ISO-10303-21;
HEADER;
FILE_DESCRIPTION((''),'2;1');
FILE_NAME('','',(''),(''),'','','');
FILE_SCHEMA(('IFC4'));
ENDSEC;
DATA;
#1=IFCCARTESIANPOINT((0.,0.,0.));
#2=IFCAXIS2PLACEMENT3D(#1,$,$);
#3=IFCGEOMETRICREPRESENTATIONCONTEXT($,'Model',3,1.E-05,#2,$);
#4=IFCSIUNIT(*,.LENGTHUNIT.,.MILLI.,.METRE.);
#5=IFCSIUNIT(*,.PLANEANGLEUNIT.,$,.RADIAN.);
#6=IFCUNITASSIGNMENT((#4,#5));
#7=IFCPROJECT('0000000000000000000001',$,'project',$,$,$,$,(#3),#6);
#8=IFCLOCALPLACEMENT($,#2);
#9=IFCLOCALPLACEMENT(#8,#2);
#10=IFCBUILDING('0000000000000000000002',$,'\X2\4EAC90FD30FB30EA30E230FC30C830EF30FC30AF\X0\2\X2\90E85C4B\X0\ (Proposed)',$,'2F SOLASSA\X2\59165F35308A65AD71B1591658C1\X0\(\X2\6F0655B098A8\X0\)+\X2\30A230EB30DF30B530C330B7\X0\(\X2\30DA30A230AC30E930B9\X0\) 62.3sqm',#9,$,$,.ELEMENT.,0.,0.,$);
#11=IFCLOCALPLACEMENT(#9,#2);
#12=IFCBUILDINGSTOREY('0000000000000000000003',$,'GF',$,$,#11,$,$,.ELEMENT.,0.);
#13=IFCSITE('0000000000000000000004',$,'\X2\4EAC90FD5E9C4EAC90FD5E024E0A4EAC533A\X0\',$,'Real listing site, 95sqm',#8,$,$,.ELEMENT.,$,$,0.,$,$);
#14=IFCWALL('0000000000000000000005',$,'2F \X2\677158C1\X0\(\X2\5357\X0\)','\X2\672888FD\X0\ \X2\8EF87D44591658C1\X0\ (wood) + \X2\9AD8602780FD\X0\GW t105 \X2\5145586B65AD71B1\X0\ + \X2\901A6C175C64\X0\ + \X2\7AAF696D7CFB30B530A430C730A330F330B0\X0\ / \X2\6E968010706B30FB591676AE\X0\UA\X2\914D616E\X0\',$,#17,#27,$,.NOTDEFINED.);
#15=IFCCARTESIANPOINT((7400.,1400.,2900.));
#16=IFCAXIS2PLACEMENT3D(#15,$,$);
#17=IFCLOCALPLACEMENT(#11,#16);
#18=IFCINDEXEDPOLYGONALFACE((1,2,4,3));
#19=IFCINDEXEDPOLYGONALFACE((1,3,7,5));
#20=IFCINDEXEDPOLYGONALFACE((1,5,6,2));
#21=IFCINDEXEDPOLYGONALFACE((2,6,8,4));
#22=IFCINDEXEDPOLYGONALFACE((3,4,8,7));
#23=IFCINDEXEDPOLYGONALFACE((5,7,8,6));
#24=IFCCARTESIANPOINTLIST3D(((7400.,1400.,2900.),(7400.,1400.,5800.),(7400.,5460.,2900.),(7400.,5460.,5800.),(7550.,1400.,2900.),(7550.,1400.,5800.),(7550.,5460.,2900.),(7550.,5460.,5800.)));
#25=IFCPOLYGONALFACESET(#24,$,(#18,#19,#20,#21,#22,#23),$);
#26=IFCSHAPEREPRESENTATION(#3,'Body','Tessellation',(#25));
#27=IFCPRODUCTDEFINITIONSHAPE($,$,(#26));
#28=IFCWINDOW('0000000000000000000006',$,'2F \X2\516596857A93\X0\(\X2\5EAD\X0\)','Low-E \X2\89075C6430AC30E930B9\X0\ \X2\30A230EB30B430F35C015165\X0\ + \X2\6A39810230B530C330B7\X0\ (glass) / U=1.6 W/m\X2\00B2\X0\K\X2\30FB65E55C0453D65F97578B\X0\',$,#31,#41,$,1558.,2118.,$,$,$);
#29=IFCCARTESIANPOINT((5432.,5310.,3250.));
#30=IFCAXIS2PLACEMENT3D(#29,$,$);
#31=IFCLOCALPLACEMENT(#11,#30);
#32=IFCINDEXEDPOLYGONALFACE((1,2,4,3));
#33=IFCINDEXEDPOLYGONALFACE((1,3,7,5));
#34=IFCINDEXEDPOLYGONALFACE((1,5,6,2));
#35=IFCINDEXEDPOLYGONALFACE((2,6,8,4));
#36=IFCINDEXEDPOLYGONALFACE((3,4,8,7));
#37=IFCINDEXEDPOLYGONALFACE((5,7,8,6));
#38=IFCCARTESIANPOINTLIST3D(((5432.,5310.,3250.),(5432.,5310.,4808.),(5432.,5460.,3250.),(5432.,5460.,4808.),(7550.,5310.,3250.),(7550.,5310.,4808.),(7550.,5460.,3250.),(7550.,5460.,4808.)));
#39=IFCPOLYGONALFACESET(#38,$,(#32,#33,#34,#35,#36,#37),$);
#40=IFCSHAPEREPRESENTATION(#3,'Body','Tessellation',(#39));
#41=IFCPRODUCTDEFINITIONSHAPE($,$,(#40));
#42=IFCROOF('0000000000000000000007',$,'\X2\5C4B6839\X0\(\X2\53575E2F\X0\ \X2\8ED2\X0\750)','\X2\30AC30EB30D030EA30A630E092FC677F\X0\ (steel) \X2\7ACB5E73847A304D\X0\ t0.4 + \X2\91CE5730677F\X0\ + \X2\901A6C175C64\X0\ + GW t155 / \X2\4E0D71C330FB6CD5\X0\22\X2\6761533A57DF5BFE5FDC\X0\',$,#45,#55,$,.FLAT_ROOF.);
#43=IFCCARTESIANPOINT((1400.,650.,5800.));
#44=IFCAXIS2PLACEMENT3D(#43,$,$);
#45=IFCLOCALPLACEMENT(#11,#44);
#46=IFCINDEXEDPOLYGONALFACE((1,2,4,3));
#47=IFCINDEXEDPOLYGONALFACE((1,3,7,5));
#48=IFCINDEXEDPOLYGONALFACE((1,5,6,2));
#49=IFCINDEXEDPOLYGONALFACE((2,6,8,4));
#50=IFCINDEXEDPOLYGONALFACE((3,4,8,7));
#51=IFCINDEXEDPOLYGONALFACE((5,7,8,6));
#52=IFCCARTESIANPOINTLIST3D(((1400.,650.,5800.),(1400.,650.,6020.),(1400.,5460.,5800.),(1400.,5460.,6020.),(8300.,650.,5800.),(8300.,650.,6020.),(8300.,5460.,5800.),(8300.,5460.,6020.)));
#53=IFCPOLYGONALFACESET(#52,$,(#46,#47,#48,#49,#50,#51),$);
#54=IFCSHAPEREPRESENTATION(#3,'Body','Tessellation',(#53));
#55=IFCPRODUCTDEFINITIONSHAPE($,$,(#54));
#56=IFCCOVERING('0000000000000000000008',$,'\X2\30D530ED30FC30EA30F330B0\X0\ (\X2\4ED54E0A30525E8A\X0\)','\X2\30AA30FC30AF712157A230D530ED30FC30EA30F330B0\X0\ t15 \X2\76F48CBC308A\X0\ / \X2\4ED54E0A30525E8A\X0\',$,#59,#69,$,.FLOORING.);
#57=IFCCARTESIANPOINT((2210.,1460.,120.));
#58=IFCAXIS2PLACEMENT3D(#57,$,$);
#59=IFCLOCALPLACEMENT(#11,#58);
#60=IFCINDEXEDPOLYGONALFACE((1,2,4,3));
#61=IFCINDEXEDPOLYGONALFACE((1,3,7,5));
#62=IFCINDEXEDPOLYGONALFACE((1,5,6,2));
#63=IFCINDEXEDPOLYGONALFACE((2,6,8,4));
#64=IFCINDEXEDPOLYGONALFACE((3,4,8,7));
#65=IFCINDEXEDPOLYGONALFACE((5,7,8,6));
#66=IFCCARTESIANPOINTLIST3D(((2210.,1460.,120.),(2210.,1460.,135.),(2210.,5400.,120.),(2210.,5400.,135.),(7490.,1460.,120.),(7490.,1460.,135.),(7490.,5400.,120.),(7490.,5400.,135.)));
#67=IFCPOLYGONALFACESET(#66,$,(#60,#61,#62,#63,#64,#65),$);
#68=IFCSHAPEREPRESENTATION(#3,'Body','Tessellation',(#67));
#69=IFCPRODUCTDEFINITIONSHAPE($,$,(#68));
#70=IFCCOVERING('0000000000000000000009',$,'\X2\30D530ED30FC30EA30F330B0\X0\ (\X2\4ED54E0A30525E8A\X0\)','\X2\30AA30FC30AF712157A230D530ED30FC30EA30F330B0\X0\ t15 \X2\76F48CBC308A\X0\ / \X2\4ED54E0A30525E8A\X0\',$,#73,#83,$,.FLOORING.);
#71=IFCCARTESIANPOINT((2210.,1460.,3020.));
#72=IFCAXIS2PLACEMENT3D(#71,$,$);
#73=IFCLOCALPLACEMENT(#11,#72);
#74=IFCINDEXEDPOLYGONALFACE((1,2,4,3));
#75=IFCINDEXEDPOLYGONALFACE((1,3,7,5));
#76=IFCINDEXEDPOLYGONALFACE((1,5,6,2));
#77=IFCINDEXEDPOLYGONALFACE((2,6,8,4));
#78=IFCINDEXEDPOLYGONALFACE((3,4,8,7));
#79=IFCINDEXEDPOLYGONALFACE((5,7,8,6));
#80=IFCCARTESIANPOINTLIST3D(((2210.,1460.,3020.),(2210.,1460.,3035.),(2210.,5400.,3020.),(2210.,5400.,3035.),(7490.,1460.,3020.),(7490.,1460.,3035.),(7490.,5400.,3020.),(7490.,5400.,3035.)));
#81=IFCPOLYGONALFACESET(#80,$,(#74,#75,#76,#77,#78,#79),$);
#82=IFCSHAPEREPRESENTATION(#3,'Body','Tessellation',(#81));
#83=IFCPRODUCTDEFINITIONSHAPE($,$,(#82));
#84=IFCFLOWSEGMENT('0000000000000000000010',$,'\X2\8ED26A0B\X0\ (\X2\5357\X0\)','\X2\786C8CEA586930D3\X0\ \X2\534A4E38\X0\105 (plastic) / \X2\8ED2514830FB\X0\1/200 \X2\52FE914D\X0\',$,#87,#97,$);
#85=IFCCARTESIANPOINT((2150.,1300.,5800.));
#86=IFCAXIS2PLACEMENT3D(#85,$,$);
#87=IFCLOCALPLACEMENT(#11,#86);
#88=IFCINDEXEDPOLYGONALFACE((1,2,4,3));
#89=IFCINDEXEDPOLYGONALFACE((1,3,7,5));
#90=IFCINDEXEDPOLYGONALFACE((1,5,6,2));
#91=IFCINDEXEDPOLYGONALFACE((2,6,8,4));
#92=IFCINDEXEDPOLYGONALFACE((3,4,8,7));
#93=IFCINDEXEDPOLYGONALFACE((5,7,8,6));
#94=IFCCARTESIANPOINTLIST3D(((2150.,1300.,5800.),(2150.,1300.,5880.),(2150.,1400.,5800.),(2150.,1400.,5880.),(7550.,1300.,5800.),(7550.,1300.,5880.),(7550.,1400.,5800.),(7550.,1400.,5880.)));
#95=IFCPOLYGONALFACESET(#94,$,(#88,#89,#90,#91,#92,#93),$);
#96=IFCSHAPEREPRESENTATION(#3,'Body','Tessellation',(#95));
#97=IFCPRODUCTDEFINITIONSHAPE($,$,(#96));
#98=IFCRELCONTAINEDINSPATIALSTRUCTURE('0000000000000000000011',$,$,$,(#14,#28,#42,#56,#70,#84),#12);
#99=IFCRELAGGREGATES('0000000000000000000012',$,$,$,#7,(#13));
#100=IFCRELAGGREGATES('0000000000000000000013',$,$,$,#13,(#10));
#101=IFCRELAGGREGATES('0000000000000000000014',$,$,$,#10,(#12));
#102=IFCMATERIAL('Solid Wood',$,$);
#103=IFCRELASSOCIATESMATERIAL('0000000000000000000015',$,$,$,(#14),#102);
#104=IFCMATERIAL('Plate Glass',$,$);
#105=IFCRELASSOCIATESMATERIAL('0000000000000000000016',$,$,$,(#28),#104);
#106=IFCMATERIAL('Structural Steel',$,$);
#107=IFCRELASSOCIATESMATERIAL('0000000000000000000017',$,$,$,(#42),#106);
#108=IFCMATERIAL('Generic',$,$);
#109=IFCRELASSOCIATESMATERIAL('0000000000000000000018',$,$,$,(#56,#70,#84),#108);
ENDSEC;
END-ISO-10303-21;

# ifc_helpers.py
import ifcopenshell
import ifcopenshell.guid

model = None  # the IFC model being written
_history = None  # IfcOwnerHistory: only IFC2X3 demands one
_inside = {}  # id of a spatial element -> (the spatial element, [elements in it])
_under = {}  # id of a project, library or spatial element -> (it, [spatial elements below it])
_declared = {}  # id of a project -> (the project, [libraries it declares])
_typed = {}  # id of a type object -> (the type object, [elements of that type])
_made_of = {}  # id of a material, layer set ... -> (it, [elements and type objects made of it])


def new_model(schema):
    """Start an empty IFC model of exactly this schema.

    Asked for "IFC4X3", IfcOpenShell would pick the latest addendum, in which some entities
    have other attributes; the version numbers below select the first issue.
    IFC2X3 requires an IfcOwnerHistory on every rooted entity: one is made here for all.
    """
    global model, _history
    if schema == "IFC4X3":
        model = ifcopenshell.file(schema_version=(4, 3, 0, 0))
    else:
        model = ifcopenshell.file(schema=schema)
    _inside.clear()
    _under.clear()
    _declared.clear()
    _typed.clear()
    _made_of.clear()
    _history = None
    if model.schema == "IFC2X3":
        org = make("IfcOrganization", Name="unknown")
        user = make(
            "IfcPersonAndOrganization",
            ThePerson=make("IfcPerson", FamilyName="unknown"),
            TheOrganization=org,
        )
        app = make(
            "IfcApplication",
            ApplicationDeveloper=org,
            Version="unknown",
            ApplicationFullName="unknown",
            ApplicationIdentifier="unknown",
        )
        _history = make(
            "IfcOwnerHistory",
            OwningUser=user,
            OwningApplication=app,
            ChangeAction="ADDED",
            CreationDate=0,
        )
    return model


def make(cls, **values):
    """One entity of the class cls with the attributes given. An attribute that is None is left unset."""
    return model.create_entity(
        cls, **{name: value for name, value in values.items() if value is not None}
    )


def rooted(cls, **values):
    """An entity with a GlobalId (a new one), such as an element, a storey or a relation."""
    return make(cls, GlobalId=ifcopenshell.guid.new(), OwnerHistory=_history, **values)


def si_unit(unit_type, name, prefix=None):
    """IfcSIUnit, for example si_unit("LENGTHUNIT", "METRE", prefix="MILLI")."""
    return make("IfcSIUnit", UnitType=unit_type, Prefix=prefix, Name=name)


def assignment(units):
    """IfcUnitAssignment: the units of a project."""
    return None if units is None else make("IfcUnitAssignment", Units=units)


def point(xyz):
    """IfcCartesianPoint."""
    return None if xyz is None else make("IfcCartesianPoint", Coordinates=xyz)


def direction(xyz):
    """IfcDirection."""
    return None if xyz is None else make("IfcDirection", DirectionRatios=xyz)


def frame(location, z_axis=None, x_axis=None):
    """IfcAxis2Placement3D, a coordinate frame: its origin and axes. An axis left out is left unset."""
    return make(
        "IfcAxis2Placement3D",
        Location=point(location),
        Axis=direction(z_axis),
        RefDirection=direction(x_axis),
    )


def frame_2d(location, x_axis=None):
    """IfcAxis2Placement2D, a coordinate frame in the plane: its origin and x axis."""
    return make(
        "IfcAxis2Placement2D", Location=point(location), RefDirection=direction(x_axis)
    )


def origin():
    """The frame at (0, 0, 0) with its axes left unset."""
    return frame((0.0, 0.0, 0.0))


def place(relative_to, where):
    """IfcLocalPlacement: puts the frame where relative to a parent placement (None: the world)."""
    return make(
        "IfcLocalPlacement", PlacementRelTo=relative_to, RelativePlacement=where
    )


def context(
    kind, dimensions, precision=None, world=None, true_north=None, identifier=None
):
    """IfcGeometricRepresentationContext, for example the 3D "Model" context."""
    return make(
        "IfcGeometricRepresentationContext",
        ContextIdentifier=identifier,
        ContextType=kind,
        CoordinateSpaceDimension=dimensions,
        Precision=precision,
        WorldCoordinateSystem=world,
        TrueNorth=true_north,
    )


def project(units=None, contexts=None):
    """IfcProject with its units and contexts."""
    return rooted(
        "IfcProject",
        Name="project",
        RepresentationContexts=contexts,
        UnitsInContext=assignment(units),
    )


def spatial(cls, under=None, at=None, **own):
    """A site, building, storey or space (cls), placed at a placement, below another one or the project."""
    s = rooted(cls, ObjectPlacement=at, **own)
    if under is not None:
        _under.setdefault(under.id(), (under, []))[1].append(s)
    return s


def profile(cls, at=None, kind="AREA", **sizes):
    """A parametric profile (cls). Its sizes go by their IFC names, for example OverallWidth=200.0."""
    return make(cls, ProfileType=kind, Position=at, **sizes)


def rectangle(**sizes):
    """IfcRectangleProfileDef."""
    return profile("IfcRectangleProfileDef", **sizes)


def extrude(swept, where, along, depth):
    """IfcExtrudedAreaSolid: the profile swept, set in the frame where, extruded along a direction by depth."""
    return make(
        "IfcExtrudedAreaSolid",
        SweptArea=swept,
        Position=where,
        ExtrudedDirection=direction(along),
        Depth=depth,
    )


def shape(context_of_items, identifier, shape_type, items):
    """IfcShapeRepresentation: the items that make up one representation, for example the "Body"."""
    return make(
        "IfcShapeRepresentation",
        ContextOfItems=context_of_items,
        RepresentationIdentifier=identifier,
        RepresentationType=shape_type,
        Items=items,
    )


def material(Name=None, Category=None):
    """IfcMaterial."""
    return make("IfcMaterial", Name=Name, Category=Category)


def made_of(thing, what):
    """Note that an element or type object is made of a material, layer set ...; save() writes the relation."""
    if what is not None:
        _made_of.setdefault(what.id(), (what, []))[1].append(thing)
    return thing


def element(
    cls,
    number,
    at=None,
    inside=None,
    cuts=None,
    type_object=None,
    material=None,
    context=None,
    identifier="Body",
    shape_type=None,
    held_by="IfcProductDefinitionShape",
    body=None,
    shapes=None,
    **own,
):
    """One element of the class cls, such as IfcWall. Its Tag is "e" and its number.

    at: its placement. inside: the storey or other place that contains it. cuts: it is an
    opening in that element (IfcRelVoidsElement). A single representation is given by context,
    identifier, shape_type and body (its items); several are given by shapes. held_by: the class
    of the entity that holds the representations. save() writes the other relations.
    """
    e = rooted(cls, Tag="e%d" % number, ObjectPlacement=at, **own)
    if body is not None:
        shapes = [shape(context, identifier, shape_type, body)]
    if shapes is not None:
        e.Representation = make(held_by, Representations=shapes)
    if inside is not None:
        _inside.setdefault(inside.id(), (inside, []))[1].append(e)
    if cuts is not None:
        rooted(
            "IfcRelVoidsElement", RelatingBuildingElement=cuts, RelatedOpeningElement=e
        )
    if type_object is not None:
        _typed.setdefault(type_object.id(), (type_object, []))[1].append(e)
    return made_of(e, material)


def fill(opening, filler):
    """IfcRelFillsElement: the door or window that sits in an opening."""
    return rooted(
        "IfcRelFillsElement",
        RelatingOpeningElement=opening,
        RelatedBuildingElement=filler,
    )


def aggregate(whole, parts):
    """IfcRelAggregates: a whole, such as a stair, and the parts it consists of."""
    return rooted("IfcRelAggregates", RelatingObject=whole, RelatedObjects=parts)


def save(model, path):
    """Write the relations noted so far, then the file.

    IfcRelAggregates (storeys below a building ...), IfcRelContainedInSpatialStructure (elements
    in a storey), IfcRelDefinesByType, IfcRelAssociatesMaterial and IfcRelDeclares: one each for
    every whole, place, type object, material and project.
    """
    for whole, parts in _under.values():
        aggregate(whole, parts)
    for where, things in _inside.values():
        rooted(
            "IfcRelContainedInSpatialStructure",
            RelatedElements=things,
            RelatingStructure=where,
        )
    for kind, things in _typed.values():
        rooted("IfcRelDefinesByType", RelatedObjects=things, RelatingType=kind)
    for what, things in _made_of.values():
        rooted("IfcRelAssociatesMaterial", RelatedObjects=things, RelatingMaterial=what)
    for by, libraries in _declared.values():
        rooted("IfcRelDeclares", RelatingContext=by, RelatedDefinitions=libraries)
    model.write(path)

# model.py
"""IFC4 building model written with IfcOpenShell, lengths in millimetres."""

from ifc_helpers import new_model, si_unit, frame, frame_2d, origin, place, context, project, spatial, rectangle, extrude, material, element, fill, save


model = new_model("IFC4")

# Units and contexts
model_context = context("Model", 3, precision=1e-05, world=origin())
ifc_project = project(units=[si_unit("LENGTHUNIT", "METRE", prefix="MILLI"), si_unit("PLANEANGLEUNIT", "RADIAN")], contexts=[model_context])

# Site, building, storey
site_placement = place(None, origin())
site = spatial("IfcSite", under=ifc_project, at=site_placement, Name="京都府京都市上京区", ObjectType="Real listing site, 95sqm", CompositionType="ELEMENT", RefElevation=0.0)
building_placement = place(site_placement, origin())
building = spatial("IfcBuilding", under=site, at=building_placement, Name="京都・リモートワーク2部屋 (Proposed)", ObjectType="2F SOLASSA外張り断熱外壁(漆喰風)+アルミサッシ(ペアガラス) 62.3sqm", CompositionType="ELEMENT", ElevationOfRefHeight=0.0, ElevationOfTerrain=0.0)
storey_placement = place(building_placement, origin())
storey = spatial("IfcBuildingStorey", under=building, at=storey_placement, Name="GF", CompositionType="ELEMENT", Elevation=0.0)

# Shared definitions
ifc_material_1 = material(Name="Solid Wood")

# Wall, opening, window
ifc_material_2 = material(Name="Plate Glass")
wall_1_placement = place(storey_placement, frame((7400.0, 1400.0, 2900.0)))
wall_1 = element("IfcWall", 1, at=wall_1_placement, inside=storey, material=ifc_material_1, Name="2F 東壁(南)", Description="木製 軸組外壁 (wood) + 高性能GW t105 充填断熱 + 通気層 + 窯業系サイディング / 準耐火・外皮UA配慮", PredefinedType="NOTDEFINED", context=model_context, shape_type="SweptSolid", body=[
    extrude(rectangle(XDim=150.0, YDim=4060.0, at=frame_2d((75.0, 2030.0))), frame((7400.0, 1400.0, 2900.0)), (0.0, 0.0, 1.0), 2900.0),
])
opening_1_placement = place(storey_placement, frame((5432.0, 5310.0, 3250.0)))
opening_1 = element("IfcOpeningElement", 2, at=opening_1_placement, cuts=wall_1, PredefinedType="NOTDEFINED", context=model_context, shape_type="SweptSolid", body=[
    extrude(rectangle(XDim=2118.0, YDim=150.0, at=frame_2d((1059.0, 75.0))), frame((5432.0, 5310.0, 3250.0)), (0.0, 0.0, 1.0), 1558.0),
])
window_1_placement = place(storey_placement, frame((5432.0, 5310.0, 3250.0)))
window_1 = element("IfcWindow", 3, at=window_1_placement, inside=storey, material=ifc_material_2, Name="2F 入隅窓(庭)", Description="Low-E 複層ガラス アルゴン封入 + 樹脂サッシ (glass) / U=1.6 W/m²K・日射取得型", OverallHeight=1558.0, OverallWidth=2118.0, context=model_context, shape_type="SweptSolid", body=[
    extrude(rectangle(XDim=2118.0, YDim=150.0, at=frame_2d((1059.0, 75.0))), frame((5432.0, 5310.0, 3250.0)), (0.0, 0.0, 1.0), 1558.0),
])
fill(opening_1, window_1)

# Roof
ifc_material_3 = material(Name="Structural Steel")
for number, where, name in (
    (4, (1400.0, 650.0, 5800.0), "屋根(南帯 軒750)"),
):
    element("IfcRoof", number, at=place(storey_placement, frame(where)), inside=storey, material=ifc_material_3, Name=name, Description="ガルバリウム鋼板 (steel) 立平葺き t0.4 + 野地板 + 通気層 + GW t155 / 不燃・法22条区域対応", PredefinedType="FLAT_ROOF", context=model_context, shape_type="SweptSolid", body=[
        extrude(rectangle(XDim=6900.0, YDim=4810.0, at=frame_2d((3450.0, 2405.0))), frame((1400.0, 650.0, 5800.0)), (0.0, 0.0, 1.0), 220.0),
    ])

# Coverings
ifc_material_4 = material(Name="Generic")
covering_1_placement = place(storey_placement, frame((2210.0, 1460.0, 120.0)))
element("IfcCovering", 5, at=covering_1_placement, inside=storey, material=ifc_material_4, Name="フローリング (仕上げ床)", Description="オーク無垢フローリング t15 直貼り / 仕上げ床", PredefinedType="FLOORING", context=model_context, shape_type="SweptSolid", body=[
    extrude(rectangle(XDim=5280.0, YDim=3940.0, at=frame_2d((2640.0, 1970.0))), frame((2210.0, 1460.0, 120.0)), (0.0, 0.0, 1.0), 15.0),
])
covering_2_placement = place(storey_placement, frame((2210.0, 1460.0, 3020.0)))
element("IfcCovering", 6, at=covering_2_placement, inside=storey, material=ifc_material_4, Name="フローリング (仕上げ床)", Description="オーク無垢フローリング t15 直貼り / 仕上げ床", PredefinedType="FLOORING", context=model_context, shape_type="SweptSolid", body=[
    extrude(rectangle(XDim=5280.0, YDim=3940.0, at=frame_2d((2640.0, 1970.0))), frame((2210.0, 1460.0, 3020.0)), (0.0, 0.0, 1.0), 15.0),
])

# Flow segment
flow_segment_placement = place(storey_placement, frame((2150.0, 1300.0, 5800.0)))
element("IfcFlowSegment", 7, at=flow_segment_placement, inside=storey, material=ifc_material_4, Name="軒樋 (南)", Description="硬質塩ビ 半丸105 (plastic) / 軒先・1/200 勾配", context=model_context, shape_type="SweptSolid", body=[
    extrude(rectangle(XDim=5400.0, YDim=100.0, at=frame_2d((2700.0, 50.0))), frame((2150.0, 1300.0, 5800.0)), (0.0, 0.0, 1.0), 80.0),
])

save(model, "model.ifc")
